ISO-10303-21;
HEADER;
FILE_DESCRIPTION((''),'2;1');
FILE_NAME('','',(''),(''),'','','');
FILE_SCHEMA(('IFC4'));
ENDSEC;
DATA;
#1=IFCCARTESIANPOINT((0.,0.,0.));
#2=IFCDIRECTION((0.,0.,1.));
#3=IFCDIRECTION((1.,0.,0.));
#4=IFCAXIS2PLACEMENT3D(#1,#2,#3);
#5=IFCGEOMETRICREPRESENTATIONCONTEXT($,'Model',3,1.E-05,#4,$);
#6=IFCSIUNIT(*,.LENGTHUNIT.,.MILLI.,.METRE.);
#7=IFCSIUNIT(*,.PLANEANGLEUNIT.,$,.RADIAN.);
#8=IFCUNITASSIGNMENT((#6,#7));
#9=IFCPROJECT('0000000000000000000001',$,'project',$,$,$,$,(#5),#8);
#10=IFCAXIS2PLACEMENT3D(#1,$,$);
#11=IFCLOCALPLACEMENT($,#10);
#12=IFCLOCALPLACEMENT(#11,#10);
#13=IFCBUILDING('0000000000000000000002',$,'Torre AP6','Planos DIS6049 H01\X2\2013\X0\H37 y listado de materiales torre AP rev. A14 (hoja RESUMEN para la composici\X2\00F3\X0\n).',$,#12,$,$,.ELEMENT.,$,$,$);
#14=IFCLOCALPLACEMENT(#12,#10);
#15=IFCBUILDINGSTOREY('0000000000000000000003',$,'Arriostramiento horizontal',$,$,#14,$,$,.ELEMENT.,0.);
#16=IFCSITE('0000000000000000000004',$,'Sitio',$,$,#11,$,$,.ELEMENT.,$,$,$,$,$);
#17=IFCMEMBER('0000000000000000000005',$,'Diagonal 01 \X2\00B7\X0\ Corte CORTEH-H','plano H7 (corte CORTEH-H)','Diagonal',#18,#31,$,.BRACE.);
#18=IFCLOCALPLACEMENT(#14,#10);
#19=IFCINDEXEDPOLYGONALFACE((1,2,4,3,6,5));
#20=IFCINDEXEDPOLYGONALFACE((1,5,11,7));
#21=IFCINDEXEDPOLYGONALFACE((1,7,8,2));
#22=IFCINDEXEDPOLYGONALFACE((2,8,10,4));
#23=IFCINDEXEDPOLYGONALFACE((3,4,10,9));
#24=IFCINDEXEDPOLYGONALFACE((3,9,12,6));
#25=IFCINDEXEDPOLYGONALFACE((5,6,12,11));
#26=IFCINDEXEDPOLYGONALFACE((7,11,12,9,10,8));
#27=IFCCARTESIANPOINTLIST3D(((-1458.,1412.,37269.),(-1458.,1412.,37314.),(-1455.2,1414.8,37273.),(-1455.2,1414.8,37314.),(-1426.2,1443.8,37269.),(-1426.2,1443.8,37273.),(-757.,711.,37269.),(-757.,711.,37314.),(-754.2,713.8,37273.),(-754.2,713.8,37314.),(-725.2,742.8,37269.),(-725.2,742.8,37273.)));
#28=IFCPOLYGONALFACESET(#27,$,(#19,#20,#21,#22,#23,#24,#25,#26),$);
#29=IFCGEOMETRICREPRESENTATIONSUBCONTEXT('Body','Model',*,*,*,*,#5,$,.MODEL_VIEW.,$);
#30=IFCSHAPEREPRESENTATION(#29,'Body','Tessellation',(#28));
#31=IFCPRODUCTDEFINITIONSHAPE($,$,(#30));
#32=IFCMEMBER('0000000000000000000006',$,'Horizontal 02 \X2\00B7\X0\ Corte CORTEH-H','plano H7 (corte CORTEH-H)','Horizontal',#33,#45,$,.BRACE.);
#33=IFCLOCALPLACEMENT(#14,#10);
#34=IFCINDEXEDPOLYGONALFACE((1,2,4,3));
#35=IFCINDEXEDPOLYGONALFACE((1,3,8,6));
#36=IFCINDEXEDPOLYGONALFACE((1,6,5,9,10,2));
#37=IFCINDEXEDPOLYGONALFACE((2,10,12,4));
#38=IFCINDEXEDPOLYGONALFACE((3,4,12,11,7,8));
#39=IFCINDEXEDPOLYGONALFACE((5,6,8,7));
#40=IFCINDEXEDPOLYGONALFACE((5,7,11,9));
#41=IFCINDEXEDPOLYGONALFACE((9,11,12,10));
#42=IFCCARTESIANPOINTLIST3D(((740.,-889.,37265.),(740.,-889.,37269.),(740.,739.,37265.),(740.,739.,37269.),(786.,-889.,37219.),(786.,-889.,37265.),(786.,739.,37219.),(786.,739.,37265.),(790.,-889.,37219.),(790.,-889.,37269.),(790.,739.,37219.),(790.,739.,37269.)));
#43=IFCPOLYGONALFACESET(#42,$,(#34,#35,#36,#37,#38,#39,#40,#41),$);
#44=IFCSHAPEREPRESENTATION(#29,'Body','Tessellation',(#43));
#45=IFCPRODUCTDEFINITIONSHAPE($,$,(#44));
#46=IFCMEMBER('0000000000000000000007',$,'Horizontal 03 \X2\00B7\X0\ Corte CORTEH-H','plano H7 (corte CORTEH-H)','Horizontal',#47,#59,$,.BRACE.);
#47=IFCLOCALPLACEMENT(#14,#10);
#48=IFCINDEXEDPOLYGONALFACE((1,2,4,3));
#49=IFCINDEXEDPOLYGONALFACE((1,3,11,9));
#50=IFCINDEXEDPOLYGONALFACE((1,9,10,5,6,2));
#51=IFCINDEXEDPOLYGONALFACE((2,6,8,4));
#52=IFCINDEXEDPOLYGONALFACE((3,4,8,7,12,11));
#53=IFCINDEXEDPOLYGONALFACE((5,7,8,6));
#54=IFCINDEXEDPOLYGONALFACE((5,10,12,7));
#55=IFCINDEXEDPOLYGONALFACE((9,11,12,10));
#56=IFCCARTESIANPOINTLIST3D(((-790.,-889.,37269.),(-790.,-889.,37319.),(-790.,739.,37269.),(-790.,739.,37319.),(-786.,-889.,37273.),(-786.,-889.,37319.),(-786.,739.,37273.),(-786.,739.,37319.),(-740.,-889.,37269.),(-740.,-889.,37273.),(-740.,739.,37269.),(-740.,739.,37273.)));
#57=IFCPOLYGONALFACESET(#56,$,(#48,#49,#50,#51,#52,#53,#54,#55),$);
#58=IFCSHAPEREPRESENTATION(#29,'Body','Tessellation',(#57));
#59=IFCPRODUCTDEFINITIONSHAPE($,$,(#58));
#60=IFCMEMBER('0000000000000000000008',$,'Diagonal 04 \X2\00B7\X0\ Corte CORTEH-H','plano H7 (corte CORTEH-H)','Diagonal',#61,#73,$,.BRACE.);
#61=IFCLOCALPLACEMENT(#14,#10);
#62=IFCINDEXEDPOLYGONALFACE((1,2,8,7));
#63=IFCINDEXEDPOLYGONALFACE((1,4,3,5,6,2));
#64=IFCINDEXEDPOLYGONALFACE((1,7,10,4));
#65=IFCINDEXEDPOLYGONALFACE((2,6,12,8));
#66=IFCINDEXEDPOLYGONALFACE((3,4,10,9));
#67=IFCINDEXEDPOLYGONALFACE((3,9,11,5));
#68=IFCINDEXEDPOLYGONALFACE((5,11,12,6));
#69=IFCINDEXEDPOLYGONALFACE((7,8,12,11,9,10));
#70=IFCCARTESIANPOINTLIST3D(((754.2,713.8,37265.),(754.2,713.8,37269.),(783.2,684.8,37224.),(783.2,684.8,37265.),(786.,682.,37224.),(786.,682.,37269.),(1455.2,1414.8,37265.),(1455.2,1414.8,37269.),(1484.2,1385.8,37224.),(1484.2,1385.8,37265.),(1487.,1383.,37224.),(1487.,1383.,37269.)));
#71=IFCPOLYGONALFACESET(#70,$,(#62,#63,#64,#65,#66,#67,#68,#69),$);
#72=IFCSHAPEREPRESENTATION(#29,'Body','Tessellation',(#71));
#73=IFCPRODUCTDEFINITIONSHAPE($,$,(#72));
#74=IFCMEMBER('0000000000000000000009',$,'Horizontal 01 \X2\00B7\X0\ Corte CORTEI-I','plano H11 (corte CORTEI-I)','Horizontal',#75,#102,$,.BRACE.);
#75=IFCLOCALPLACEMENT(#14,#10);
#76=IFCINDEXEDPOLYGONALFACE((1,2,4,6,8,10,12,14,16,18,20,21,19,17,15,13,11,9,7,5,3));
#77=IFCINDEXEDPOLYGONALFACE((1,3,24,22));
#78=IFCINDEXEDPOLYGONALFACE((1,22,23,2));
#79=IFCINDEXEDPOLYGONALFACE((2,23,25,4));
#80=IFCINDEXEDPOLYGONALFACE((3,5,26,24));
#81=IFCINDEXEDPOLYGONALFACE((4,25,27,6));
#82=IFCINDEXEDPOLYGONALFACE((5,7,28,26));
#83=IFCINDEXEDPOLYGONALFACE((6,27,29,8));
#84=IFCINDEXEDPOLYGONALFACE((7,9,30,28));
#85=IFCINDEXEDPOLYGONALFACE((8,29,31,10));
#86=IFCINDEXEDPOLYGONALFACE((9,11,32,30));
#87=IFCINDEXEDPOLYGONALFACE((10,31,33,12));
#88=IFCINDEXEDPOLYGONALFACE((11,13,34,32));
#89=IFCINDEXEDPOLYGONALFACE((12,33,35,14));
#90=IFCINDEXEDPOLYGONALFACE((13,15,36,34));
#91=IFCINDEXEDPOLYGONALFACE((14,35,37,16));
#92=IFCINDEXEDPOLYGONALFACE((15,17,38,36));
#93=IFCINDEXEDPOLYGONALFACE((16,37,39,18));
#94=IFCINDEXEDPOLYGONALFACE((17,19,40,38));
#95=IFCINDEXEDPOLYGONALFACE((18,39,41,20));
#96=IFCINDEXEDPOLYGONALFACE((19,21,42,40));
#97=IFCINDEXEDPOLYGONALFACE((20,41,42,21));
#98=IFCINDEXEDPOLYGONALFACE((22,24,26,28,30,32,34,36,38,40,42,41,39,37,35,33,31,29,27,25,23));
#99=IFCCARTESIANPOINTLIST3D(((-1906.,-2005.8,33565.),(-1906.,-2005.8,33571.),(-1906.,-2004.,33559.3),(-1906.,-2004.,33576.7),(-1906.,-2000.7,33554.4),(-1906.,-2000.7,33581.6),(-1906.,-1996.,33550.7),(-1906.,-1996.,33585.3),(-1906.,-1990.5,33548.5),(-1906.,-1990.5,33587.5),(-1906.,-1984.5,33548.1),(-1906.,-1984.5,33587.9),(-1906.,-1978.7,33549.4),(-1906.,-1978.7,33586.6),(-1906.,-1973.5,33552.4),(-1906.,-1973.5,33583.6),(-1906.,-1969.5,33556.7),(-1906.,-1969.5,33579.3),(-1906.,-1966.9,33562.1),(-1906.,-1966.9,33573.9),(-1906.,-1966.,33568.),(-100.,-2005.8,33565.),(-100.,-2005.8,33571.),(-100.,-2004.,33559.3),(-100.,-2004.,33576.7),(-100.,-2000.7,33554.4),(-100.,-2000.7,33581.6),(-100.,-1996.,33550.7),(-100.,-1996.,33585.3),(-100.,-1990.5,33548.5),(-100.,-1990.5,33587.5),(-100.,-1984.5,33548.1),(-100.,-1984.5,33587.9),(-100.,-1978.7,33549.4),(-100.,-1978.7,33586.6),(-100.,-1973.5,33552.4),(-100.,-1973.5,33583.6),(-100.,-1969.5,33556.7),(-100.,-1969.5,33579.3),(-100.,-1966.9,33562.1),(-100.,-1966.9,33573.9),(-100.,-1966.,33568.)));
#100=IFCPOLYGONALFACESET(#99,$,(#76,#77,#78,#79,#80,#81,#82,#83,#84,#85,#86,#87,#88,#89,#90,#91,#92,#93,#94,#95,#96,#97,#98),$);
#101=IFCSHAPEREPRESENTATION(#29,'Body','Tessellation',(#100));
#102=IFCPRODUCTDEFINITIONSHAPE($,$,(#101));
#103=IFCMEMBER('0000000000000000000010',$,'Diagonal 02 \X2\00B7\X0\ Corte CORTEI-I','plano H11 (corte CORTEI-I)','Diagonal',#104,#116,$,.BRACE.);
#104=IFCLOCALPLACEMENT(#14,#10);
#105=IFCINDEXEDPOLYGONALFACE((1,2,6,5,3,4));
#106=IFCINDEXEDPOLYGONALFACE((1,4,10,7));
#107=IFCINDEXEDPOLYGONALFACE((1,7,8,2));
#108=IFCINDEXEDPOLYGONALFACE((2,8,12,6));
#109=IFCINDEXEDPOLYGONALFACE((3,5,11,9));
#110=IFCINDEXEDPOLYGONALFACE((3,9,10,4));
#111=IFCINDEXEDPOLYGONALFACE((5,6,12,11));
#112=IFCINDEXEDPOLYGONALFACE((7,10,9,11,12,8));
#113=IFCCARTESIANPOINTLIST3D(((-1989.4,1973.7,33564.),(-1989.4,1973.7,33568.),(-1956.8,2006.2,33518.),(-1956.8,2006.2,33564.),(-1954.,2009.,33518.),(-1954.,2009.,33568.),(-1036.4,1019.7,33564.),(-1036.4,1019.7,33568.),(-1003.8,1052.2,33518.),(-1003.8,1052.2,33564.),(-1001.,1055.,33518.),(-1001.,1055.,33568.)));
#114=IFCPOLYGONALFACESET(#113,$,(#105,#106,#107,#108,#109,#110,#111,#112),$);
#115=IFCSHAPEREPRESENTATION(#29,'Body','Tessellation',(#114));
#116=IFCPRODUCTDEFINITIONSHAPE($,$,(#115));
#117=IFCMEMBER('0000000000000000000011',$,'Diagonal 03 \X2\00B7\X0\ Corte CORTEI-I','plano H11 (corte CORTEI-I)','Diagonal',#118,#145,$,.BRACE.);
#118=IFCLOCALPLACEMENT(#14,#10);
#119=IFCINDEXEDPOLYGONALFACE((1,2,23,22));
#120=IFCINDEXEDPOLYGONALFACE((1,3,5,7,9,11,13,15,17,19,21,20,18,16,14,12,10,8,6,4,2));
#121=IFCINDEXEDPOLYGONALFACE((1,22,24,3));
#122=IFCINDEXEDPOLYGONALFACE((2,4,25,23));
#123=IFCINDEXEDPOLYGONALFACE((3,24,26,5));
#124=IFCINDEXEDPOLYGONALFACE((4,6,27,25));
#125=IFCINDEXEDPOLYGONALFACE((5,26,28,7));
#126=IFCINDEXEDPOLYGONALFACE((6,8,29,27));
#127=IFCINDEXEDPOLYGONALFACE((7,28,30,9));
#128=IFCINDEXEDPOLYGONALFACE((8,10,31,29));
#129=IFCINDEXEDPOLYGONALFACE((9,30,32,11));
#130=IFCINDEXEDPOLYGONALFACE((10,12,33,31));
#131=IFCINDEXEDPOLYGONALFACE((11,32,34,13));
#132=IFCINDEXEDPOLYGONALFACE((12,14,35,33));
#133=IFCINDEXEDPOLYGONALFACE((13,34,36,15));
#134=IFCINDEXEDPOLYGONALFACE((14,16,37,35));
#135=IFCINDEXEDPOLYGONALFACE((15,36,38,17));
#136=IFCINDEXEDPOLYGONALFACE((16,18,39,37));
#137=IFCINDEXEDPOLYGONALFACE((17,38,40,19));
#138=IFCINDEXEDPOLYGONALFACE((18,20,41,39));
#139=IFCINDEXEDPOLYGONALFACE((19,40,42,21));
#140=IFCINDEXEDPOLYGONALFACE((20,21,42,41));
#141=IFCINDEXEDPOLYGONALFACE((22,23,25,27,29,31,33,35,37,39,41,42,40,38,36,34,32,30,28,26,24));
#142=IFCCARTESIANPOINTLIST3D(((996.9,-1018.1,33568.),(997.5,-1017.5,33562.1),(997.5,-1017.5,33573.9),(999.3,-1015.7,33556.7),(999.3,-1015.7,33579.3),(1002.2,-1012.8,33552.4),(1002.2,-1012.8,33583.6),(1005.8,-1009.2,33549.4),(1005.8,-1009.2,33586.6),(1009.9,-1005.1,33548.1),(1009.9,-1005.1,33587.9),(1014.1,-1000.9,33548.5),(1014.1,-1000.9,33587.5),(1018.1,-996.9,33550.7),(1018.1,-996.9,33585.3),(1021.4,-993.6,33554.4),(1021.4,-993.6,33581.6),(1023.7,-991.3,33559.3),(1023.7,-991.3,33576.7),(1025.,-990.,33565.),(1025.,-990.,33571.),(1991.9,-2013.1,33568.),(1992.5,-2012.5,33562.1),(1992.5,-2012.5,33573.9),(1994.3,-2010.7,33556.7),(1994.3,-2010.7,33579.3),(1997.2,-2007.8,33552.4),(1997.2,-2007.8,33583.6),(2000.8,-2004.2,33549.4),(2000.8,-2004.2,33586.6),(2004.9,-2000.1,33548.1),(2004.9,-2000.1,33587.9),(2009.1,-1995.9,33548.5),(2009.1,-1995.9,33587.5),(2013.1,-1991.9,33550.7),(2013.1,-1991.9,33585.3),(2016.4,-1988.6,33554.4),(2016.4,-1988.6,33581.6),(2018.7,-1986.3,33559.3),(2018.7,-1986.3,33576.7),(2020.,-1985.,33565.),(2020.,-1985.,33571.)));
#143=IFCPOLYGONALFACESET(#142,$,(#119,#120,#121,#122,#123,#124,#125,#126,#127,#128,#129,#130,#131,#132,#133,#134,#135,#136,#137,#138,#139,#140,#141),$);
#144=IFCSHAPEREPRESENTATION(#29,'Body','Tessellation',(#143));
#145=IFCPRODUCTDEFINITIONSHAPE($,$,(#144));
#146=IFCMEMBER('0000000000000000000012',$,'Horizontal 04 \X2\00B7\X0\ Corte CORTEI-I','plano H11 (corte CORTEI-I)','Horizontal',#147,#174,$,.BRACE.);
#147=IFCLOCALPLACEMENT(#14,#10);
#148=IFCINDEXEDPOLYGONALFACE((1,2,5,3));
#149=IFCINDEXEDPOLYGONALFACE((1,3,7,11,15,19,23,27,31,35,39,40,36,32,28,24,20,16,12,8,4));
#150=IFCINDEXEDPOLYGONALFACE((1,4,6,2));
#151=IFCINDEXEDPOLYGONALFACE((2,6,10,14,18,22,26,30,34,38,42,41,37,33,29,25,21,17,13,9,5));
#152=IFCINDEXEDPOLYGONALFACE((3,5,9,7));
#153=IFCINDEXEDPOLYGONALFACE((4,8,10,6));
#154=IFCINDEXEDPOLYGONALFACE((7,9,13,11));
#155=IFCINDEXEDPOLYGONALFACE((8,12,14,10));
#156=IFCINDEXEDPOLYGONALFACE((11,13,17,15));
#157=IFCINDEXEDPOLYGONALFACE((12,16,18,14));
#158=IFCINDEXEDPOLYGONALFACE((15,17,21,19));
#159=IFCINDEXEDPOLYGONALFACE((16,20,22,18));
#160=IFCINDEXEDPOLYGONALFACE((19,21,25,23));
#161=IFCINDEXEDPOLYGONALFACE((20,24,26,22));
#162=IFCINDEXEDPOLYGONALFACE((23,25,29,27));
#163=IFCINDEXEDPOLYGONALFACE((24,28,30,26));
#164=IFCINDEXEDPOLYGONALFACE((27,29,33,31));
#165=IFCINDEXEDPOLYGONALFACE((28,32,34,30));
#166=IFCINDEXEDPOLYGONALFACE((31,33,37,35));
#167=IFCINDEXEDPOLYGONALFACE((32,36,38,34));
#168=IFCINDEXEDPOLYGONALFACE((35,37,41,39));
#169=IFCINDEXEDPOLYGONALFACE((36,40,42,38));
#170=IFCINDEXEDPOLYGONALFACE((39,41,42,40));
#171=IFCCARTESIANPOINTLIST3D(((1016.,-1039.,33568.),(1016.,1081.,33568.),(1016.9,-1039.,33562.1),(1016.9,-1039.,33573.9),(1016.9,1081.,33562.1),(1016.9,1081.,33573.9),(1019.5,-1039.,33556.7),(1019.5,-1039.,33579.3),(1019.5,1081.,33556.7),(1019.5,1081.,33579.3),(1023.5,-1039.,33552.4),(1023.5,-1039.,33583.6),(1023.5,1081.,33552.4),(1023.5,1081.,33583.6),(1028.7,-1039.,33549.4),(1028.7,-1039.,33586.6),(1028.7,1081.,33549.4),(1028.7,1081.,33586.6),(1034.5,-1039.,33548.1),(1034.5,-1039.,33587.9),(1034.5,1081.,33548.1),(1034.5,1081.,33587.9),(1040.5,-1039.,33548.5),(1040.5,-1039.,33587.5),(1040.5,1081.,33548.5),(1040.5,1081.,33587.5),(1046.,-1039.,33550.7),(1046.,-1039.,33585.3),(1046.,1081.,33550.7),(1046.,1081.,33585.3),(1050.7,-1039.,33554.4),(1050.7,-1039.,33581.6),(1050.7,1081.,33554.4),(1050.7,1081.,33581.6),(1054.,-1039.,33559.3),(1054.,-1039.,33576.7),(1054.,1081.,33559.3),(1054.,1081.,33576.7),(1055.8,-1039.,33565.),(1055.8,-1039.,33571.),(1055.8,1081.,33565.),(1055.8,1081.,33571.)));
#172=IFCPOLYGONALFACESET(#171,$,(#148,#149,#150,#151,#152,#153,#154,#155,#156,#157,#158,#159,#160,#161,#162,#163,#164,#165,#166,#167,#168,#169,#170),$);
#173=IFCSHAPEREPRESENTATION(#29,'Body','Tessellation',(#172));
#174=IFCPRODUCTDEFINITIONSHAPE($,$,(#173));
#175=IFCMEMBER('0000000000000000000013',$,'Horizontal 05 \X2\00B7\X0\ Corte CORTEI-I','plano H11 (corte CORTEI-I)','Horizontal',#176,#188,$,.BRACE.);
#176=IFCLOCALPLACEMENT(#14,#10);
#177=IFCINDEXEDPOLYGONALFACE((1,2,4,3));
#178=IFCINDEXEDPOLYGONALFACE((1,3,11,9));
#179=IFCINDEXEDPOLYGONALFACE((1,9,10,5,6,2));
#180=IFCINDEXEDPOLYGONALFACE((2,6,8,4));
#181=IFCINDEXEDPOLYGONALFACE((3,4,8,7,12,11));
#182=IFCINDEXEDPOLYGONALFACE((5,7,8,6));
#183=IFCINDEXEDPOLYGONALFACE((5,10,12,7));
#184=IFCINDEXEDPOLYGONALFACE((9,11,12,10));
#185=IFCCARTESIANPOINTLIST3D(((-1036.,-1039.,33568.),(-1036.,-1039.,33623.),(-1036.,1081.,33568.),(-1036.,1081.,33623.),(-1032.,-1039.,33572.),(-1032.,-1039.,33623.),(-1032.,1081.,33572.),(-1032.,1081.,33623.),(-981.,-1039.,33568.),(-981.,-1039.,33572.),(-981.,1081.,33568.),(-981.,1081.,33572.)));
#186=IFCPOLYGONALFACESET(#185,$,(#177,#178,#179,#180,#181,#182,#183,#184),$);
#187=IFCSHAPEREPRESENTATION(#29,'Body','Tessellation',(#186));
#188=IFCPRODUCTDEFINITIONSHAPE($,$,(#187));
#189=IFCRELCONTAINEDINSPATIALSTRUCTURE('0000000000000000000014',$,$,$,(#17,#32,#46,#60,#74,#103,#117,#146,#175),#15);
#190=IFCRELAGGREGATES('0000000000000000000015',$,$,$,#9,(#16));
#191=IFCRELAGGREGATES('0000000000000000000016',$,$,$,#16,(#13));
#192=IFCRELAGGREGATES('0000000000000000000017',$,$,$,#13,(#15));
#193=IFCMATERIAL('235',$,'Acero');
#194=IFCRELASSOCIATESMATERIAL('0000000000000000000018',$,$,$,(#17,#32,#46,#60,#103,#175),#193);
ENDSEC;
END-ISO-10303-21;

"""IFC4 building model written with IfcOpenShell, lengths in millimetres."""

from ifc_helpers import new_model, si_unit, frame, frame_2d, origin, origin_with_axes, place, context, subcontext, project, spatial, circle, l_section, extrude, material, element, save


model = new_model("IFC4")

# Units and contexts
model_context = context("Model", 3, precision=1e-05, world=origin_with_axes())
body_context = subcontext(model_context, "Body", "Model", "MODEL_VIEW")
ifc_project = project(units=[si_unit("LENGTHUNIT", "METRE", prefix="MILLI"), si_unit("PLANEANGLEUNIT", "RADIAN")], contexts=[model_context])

# Site, building, storey
site_placement = place(None, origin())
site = spatial("IfcSite", under=ifc_project, at=site_placement, Name="Sitio", CompositionType="ELEMENT")
building_placement = place(site_placement, origin())
building = spatial("IfcBuilding", under=site, at=building_placement, Name="Torre AP6", Description="Planos DIS6049 H01–H37 y listado de materiales torre AP rev. A14 (hoja RESUMEN para la composición).", CompositionType="ELEMENT")
storey_placement = place(building_placement, origin())
storey = spatial("IfcBuildingStorey", under=building, at=storey_placement, Name="Arriostramiento horizontal", CompositionType="ELEMENT", Elevation=0.0)

# Members
ifc_material = material(Name="235", Category="Acero")
member_1_placement = place(storey_placement, frame((-1458.0, 1412.0, 37269.0), z_axis=(0.707107, -0.707107, 0.0), x_axis=(0.707107, 0.707107, 0.0)))
element("IfcMember", 1, at=member_1_placement, inside=storey, material=ifc_material, Name="Diagonal 01 · Corte CORTEH-H", Description="plano H7 (corte CORTEH-H)", ObjectType="Diagonal", PredefinedType="BRACE", context=body_context, shape_type="SweptSolid", body=[
    extrude(l_section(Depth=45.0, Width=45.0, Thickness=4.0, at=frame_2d((22.5, 22.5))), None, (0.0, 0.0, 1.0), 991.4),
])
for number, where, z_axis, x_axis, name in (
    (2, (790.0, 739.0, 37269.0), (0.0, -1.0, 0.0), (-1.0, 0.0, 0.0), "Horizontal 02 · Corte CORTEH-H"),
    (3, (-790.0, 739.0, 37269.0), (0.0, -1.0, 0.0), (1.0, 0.0, 0.0), "Horizontal 03 · Corte CORTEH-H"),
):
    element("IfcMember", number, at=place(storey_placement, frame(where, z_axis=z_axis, x_axis=x_axis)), inside=storey, material=ifc_material, Name=name, Description="plano H7 (corte CORTEH-H)", ObjectType="Horizontal", PredefinedType="BRACE", context=body_context, shape_type="SweptSolid", body=[
        extrude(l_section(Depth=50.0, Width=50.0, Thickness=4.0, at=frame_2d((25.0, 25.0))), None, (0.0, 0.0, 1.0), 1628.0),
    ])
member_2_placement = place(storey_placement, frame((1487.0, 1383.0, 37269.0), z_axis=(-0.707107, -0.707107, 0.0), x_axis=(-0.707107, 0.707107, 0.0)))
element("IfcMember", 4, at=member_2_placement, inside=storey, material=ifc_material, Name="Diagonal 04 · Corte CORTEH-H", Description="plano H7 (corte CORTEH-H)", ObjectType="Diagonal", PredefinedType="BRACE", context=body_context, shape_type="SweptSolid", body=[
    extrude(l_section(Depth=45.0, Width=45.0, Thickness=4.0, at=frame_2d((22.5, 22.5))), None, (0.0, 0.0, 1.0), 991.4),
])
member_3_placement = place(storey_placement, frame((-1906.0, -1986.0, 33568.0), z_axis=(1.0, 0.0, 0.0), x_axis=(0.0, 1.0, 0.0)))
element("IfcMember", 5, at=member_3_placement, inside=storey, Name="Horizontal 01 · Corte CORTEI-I", Description="plano H11 (corte CORTEI-I)", ObjectType="Horizontal", PredefinedType="BRACE", context=body_context, shape_type="SweptSolid", body=[
    extrude(circle(Radius=20.0), None, (0.0, 0.0, 1.0), 1806.0),
])
member_4_placement = place(storey_placement, frame((-1954.0, 2009.0, 33568.0), z_axis=(0.706736, -0.707477, 0.0), x_axis=(-0.707477, -0.706736, 0.0)))
element("IfcMember", 6, at=member_4_placement, inside=storey, material=ifc_material, Name="Diagonal 02 · Corte CORTEI-I", Description="plano H11 (corte CORTEI-I)", ObjectType="Diagonal", PredefinedType="BRACE", context=body_context, shape_type="SweptSolid", body=[
    extrude(l_section(Depth=50.0, Width=50.0, Thickness=4.0, at=frame_2d((25.0, 25.0))), None, (0.0, 0.0, 1.0), 1348.5),
])
member_5_placement = place(storey_placement, frame((1011.0, -1004.0, 33568.0), z_axis=(0.707107, -0.707107, 0.0), x_axis=(-0.707107, -0.707107, 0.0)))
element("IfcMember", 7, at=member_5_placement, inside=storey, Name="Diagonal 03 · Corte CORTEI-I", Description="plano H11 (corte CORTEI-I)", ObjectType="Diagonal", PredefinedType="BRACE", context=body_context, shape_type="SweptSolid", body=[
    extrude(circle(Radius=20.0), None, (0.0, 0.0, 1.0), 1407.1),
])
member_6_placement = place(storey_placement, frame((1036.0, 1081.0, 33568.0), z_axis=(0.0, -1.0, 0.0), x_axis=(-1.0, 0.0, 0.0)))
element("IfcMember", 8, at=member_6_placement, inside=storey, Name="Horizontal 04 · Corte CORTEI-I", Description="plano H11 (corte CORTEI-I)", ObjectType="Horizontal", PredefinedType="BRACE", context=body_context, shape_type="SweptSolid", body=[
    extrude(circle(Radius=20.0), None, (0.0, 0.0, 1.0), 2120.0),
])
member_7_placement = place(storey_placement, frame((-1036.0, 1081.0, 33568.0), z_axis=(0.0, -1.0, 0.0), x_axis=(1.0, 0.0, 0.0)))
element("IfcMember", 9, at=member_7_placement, inside=storey, material=ifc_material, Name="Horizontal 05 · Corte CORTEI-I", Description="plano H11 (corte CORTEI-I)", ObjectType="Horizontal", PredefinedType="BRACE", context=body_context, shape_type="SweptSolid", body=[
    extrude(l_section(Depth=55.0, Width=55.0, Thickness=4.0, at=frame_2d((27.5, 27.5))), None, (0.0, 0.0, 1.0), 2120.0),
])

save(model, "model.ifc")
